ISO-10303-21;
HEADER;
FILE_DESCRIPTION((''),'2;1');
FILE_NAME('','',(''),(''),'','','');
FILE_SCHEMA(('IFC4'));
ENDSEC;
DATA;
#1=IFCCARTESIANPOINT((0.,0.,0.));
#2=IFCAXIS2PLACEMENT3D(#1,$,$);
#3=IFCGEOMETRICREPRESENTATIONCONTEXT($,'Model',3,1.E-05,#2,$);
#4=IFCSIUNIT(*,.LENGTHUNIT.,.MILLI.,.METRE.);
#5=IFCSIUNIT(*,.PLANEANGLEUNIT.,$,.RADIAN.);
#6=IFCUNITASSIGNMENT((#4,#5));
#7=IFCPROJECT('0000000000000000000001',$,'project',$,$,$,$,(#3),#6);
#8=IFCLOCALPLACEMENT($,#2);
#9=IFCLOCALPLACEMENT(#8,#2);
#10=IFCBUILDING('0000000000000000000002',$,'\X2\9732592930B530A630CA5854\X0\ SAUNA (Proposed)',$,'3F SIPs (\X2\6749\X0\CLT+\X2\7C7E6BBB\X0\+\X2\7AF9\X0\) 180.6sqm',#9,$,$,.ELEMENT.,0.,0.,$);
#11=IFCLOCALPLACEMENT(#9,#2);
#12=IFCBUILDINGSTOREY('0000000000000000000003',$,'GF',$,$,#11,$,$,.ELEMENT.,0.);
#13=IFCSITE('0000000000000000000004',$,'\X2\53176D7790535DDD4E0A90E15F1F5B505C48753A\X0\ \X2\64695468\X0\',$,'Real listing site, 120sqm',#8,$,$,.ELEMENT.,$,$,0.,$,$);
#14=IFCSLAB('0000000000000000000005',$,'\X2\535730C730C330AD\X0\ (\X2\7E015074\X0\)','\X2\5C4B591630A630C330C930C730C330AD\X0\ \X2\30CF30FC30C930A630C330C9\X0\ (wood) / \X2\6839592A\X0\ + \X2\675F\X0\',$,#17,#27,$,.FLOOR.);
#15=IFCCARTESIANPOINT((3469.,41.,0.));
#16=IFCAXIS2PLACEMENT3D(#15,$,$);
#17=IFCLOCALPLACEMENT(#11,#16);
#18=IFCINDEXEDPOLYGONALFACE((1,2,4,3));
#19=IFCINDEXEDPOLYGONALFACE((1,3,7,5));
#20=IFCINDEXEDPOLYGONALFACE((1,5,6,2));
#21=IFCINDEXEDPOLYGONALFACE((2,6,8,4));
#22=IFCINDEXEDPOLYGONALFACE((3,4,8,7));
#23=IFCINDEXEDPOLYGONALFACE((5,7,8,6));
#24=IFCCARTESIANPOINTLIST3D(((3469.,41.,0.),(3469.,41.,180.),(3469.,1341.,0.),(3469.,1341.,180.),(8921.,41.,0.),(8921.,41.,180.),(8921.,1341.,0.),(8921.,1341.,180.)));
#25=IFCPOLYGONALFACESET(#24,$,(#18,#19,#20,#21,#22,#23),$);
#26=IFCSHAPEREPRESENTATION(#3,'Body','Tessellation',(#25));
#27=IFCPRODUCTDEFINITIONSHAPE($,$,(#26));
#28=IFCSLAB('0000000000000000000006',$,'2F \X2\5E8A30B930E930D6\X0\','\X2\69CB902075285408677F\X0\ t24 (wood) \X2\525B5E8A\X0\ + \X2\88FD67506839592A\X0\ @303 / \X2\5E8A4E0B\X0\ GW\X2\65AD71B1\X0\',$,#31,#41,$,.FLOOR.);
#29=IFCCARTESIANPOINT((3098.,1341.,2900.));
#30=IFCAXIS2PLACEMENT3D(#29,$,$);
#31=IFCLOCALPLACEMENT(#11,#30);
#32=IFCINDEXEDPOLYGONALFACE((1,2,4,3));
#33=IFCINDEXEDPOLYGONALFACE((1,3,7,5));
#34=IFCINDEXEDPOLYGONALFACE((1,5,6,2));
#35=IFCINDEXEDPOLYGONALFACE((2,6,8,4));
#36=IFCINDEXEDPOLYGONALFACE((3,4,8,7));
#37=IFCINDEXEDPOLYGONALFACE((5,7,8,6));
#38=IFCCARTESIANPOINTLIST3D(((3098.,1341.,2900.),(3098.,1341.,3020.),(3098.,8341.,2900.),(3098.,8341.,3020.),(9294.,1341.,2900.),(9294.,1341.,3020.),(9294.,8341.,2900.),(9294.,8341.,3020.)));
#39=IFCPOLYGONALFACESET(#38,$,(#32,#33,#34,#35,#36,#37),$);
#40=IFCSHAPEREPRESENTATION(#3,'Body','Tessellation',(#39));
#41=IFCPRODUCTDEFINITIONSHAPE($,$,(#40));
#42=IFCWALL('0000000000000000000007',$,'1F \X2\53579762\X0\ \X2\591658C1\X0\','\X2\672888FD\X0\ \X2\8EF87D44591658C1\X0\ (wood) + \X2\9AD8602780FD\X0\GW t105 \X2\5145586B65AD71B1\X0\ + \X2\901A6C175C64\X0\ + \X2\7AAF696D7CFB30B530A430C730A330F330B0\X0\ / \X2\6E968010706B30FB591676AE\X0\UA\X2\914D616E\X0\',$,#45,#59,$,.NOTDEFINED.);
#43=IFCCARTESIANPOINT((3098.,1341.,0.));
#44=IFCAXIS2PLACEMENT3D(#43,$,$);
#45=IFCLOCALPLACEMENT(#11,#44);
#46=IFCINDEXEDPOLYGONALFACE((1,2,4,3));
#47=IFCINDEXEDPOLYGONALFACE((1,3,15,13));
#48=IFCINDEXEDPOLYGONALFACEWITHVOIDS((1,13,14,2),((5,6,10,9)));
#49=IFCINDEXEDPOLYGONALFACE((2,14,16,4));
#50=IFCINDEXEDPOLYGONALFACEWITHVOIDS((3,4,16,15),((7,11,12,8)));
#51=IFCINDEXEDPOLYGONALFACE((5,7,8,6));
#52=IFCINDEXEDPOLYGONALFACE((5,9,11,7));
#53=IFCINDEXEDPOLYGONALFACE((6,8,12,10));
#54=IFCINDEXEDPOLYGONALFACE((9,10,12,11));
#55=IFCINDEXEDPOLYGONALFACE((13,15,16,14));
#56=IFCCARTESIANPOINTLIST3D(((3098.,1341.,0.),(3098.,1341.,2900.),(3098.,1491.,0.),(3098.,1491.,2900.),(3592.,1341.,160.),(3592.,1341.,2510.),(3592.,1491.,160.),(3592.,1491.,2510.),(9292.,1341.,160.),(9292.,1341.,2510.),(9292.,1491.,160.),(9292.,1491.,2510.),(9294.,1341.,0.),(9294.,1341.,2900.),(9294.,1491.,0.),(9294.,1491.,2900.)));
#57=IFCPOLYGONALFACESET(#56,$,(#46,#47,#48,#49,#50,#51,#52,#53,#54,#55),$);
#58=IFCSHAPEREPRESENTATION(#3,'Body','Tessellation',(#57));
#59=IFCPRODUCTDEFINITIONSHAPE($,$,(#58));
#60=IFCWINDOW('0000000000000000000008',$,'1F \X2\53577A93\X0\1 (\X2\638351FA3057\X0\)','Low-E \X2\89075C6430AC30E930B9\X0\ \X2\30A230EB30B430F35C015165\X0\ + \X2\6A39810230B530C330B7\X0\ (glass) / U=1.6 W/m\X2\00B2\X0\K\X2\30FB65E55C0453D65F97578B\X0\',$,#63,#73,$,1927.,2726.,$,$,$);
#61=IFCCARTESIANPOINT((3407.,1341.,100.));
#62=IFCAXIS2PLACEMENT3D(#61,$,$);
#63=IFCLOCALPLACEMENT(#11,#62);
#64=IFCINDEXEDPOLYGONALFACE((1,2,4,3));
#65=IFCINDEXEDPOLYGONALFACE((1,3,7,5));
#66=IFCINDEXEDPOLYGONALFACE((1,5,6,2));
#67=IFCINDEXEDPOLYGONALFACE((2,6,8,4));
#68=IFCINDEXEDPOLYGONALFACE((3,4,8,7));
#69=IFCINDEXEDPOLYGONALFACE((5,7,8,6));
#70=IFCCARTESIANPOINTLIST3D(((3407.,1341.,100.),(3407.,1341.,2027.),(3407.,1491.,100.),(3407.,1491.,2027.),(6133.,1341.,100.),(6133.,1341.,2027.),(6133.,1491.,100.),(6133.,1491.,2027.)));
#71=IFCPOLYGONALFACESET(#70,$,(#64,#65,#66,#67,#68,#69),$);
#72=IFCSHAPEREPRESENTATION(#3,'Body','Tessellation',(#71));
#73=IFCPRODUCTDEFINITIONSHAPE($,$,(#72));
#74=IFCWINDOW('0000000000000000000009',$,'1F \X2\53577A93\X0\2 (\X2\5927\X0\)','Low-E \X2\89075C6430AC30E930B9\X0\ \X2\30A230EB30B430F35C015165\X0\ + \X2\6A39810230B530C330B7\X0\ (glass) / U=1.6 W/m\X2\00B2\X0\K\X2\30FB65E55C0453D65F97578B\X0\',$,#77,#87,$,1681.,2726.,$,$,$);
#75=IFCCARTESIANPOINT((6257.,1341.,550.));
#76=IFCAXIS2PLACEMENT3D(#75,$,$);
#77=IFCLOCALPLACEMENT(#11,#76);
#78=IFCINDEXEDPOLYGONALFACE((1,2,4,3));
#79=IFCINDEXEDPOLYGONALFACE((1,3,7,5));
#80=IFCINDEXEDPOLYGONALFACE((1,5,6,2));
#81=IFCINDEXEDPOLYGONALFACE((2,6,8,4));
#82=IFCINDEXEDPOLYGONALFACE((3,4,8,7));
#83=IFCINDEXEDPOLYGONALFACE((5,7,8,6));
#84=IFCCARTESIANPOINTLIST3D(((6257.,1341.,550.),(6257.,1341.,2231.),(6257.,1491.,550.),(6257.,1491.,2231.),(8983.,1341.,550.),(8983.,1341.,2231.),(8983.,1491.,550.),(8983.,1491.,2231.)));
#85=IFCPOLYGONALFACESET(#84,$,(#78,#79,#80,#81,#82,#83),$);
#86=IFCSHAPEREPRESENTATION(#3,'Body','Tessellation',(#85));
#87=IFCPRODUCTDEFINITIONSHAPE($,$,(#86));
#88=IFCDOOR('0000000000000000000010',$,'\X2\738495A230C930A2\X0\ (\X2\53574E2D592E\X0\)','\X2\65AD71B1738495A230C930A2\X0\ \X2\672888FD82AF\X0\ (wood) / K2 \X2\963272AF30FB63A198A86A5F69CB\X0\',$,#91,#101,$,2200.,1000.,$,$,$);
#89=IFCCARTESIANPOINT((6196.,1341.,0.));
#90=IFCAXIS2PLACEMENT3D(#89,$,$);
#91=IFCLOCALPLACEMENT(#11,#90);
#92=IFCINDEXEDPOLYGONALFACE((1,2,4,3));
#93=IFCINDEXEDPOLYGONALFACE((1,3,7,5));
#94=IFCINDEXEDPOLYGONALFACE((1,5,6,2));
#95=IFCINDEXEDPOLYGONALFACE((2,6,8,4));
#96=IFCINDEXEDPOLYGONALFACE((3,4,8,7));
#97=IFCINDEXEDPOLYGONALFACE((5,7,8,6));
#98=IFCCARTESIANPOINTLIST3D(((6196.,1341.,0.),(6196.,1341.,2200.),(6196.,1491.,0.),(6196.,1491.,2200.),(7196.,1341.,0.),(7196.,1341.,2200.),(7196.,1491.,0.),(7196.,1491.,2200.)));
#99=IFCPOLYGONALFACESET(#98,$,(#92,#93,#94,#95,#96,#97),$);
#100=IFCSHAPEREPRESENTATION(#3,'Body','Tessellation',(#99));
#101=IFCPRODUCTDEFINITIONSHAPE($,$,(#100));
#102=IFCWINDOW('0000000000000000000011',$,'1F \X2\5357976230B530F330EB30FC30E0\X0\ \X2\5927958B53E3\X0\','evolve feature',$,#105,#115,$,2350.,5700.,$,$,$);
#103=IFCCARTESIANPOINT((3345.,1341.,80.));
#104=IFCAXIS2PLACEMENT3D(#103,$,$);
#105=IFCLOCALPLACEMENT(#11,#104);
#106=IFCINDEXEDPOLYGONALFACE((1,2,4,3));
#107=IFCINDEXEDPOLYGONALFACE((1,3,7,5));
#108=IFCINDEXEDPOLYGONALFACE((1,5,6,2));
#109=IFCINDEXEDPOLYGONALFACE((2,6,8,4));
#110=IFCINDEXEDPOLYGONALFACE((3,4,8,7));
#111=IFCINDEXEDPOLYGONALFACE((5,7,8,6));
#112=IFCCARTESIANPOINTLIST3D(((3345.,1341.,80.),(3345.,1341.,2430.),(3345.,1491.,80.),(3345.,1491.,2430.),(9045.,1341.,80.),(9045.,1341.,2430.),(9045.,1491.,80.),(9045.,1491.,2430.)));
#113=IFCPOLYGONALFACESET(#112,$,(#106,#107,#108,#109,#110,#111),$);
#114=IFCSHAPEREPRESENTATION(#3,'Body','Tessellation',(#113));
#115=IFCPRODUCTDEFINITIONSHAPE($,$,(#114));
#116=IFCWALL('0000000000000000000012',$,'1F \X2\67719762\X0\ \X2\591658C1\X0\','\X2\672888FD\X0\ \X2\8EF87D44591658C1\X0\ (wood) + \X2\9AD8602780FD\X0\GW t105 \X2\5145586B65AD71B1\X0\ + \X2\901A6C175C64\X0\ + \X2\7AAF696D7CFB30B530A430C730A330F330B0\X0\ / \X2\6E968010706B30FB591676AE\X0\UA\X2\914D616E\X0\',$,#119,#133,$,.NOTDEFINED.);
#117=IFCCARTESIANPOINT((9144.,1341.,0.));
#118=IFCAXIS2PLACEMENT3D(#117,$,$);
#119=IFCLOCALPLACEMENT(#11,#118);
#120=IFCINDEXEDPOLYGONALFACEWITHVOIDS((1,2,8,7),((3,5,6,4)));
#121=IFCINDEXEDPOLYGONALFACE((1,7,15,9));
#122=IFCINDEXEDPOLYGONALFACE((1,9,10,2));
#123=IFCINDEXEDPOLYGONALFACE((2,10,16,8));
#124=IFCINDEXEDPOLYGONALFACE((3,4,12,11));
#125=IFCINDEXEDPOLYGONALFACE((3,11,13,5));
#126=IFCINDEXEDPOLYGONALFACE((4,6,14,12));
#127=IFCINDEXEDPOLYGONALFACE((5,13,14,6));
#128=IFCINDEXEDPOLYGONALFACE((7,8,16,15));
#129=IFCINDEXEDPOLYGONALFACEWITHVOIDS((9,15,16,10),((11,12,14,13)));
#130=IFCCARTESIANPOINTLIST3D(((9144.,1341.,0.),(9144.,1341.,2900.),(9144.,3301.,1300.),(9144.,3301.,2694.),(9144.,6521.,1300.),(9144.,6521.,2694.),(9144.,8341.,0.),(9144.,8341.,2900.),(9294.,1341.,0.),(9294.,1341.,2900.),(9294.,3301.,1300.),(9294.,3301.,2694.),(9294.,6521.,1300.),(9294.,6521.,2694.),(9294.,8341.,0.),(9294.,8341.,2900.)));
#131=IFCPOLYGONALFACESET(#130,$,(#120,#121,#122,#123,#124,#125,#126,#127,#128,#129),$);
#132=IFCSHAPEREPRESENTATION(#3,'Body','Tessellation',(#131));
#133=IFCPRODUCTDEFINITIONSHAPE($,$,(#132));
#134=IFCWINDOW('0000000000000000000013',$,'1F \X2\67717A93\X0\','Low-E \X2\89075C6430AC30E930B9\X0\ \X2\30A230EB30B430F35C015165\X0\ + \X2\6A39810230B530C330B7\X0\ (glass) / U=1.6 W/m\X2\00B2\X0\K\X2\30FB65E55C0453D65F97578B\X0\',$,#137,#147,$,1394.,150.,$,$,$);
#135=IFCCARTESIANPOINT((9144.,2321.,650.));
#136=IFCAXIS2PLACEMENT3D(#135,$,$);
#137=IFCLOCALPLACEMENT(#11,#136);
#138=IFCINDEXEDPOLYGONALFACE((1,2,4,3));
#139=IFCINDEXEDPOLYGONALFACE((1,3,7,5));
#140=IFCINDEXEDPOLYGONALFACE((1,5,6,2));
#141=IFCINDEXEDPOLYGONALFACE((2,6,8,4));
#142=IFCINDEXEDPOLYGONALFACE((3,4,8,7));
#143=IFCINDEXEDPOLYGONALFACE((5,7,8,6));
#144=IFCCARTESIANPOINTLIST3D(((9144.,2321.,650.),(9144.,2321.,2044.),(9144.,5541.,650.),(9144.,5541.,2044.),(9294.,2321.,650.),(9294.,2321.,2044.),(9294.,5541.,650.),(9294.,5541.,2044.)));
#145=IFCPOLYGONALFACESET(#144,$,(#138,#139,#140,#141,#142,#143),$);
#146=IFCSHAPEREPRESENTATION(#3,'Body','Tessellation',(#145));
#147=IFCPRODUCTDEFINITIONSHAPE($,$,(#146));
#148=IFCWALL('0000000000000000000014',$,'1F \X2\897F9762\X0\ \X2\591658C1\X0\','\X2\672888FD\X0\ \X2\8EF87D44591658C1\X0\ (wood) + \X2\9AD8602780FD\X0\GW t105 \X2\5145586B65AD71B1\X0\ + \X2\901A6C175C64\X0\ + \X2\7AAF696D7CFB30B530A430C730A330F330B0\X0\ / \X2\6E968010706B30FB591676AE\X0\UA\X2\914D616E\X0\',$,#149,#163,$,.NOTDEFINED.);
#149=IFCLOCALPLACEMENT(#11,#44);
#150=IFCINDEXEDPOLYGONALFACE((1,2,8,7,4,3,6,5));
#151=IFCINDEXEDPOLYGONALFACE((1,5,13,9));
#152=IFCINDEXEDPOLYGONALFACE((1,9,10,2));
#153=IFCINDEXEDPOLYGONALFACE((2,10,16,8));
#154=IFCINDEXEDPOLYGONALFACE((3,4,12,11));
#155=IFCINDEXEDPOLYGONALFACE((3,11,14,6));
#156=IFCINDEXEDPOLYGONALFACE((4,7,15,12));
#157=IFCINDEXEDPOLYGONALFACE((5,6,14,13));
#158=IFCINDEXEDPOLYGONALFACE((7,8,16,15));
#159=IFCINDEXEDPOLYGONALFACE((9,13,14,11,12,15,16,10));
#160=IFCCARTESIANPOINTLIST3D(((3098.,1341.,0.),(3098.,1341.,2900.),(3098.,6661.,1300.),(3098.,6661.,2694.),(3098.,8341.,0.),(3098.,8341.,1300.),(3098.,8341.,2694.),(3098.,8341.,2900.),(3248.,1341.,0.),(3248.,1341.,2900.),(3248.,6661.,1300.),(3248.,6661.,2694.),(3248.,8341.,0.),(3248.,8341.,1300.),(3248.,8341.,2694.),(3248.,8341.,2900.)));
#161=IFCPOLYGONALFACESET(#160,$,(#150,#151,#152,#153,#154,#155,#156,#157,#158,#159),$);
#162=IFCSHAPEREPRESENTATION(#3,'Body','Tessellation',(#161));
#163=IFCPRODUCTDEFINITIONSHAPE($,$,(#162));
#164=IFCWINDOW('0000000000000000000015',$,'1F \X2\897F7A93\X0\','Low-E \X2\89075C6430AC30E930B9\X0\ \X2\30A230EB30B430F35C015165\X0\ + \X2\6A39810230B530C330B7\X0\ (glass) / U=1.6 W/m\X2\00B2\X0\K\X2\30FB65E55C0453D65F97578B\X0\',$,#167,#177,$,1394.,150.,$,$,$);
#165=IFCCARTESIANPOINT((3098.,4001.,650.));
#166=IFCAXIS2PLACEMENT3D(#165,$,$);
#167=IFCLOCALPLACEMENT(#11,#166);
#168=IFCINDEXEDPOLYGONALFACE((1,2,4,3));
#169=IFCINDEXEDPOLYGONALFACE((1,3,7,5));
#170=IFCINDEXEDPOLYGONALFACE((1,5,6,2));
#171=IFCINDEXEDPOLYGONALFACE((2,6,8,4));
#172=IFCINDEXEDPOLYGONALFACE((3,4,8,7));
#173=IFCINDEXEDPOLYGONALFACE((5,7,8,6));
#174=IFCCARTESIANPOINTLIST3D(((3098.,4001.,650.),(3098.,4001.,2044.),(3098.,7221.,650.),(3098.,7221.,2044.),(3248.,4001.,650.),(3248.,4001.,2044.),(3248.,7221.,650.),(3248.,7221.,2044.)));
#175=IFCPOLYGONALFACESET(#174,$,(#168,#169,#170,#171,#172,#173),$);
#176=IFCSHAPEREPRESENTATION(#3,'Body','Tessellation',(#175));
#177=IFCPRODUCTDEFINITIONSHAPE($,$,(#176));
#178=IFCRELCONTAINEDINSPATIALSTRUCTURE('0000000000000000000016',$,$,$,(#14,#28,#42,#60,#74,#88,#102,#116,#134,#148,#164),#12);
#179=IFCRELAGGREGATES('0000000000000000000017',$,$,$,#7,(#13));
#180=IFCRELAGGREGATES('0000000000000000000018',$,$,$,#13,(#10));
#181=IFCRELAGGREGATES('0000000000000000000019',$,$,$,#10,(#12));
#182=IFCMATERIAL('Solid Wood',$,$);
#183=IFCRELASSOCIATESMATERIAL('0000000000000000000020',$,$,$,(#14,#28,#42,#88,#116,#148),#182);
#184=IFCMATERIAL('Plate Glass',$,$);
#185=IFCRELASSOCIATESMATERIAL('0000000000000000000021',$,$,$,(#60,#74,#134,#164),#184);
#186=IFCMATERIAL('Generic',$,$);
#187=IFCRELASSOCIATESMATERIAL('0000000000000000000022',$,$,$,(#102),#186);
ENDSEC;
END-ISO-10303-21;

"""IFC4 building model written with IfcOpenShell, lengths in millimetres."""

from ifc_helpers import new_model, si_unit, frame, frame_2d, origin, place, context, project, spatial, rectangle, extrude, material, element, fill, save


model = new_model("IFC4")

# Units and contexts
model_context = context("Model", 3, precision=1e-05, world=origin())
ifc_project = project(units=[si_unit("LENGTHUNIT", "METRE", prefix="MILLI"), si_unit("PLANEANGLEUNIT", "RADIAN")], contexts=[model_context])

# Site, building, storey
site_placement = place(None, origin())
site = spatial("IfcSite", under=ifc_project, at=site_placement, Name="北海道川上郡弟子屈町 摩周", ObjectType="Real listing site, 120sqm", CompositionType="ELEMENT", RefElevation=0.0)
building_placement = place(site_placement, origin())
building = spatial("IfcBuilding", under=site, at=building_placement, Name="露天サウナ塔 SAUNA (Proposed)", ObjectType="3F SIPs (杉CLT+籾殻+竹) 180.6sqm", CompositionType="ELEMENT", ElevationOfRefHeight=0.0, ElevationOfTerrain=0.0)
storey_placement = place(building_placement, origin())
storey = spatial("IfcBuildingStorey", under=building, at=storey_placement, Name="GF", CompositionType="ELEMENT", Elevation=0.0)

# Slabs
ifc_material_1 = material(Name="Solid Wood")
slab_1_placement = place(storey_placement, frame((3469.0, 41.0, 0.0)))
element("IfcSlab", 1, at=slab_1_placement, inside=storey, material=ifc_material_1, Name="南デッキ (縁側)", Description="屋外ウッドデッキ ハードウッド (wood) / 根太 + 束", PredefinedType="FLOOR", context=model_context, shape_type="SweptSolid", body=[
    extrude(rectangle(XDim=5452.0, YDim=1300.0, at=frame_2d((2726.0, 650.0))), frame((3469.0, 41.0, 0.0)), (0.0, 0.0, 1.0), 180.0),
])
slab_2_placement = place(storey_placement, frame((3098.0, 1341.0, 2900.0)))
element("IfcSlab", 2, at=slab_2_placement, inside=storey, material=ifc_material_1, Name="2F 床スラブ", Description="構造用合板 t24 (wood) 剛床 + 製材根太 @303 / 床下 GW断熱", PredefinedType="FLOOR", context=model_context, shape_type="SweptSolid", body=[
    extrude(rectangle(XDim=6196.0, YDim=7000.0, at=frame_2d((3098.0, 3500.0))), frame((3098.0, 1341.0, 2900.0)), (0.0, 0.0, 1.0), 120.0),
])

# Wall, openings, windows, door
wall_1_placement = place(storey_placement, frame((3098.0, 1341.0, 0.0)))
wall_1 = element("IfcWall", 3, at=wall_1_placement, inside=storey, material=ifc_material_1, Name="1F 南面 外壁", Description="木製 軸組外壁 (wood) + 高性能GW t105 充填断熱 + 通気層 + 窯業系サイディング / 準耐火・外皮UA配慮", PredefinedType="NOTDEFINED", context=model_context, shape_type="SweptSolid", body=[
    extrude(rectangle(XDim=6196.0, YDim=150.0, at=frame_2d((3098.0, 75.0))), frame((3098.0, 1341.0, 0.0)), (0.0, 0.0, 1.0), 2900.0),
])
opening_1_placement = place(storey_placement, frame((3407.0, 1341.0, 100.0)))
opening_1 = element("IfcOpeningElement", 4, at=opening_1_placement, cuts=wall_1, PredefinedType="NOTDEFINED", context=model_context, shape_type="SweptSolid", body=[
    extrude(rectangle(XDim=2726.0, YDim=150.0, at=frame_2d((1363.0, 75.0))), frame((3407.0, 1341.0, 100.0)), (0.0, 0.0, 1.0), 1927.0),
])
opening_2_placement = place(storey_placement, frame((6257.0, 1341.0, 550.0)))
opening_2 = element("IfcOpeningElement", 5, at=opening_2_placement, cuts=wall_1, PredefinedType="NOTDEFINED", context=model_context, shape_type="SweptSolid", body=[
    extrude(rectangle(XDim=2726.0, YDim=150.0, at=frame_2d((1363.0, 75.0))), frame((6257.0, 1341.0, 550.0)), (0.0, 0.0, 1.0), 1681.0),
])
opening_3_placement = place(storey_placement, frame((6196.0, 1341.0, 0.0)))
opening_3 = element("IfcOpeningElement", 6, at=opening_3_placement, cuts=wall_1, PredefinedType="NOTDEFINED", context=model_context, shape_type="SweptSolid", body=[
    extrude(rectangle(XDim=1000.0, YDim=150.0, at=frame_2d((500.0, 75.0))), frame((6196.0, 1341.0, 0.0)), (0.0, 0.0, 1.0), 2200.0),
])
opening_4_placement = place(storey_placement, frame((3345.0, 1341.0, 80.0)))
opening_4 = element("IfcOpeningElement", 7, at=opening_4_placement, cuts=wall_1, PredefinedType="NOTDEFINED", context=model_context, shape_type="SweptSolid", body=[
    extrude(rectangle(XDim=5700.0, YDim=150.0, at=frame_2d((2850.0, 75.0))), frame((3345.0, 1341.0, 80.0)), (0.0, 0.0, 1.0), 2350.0),
])
ifc_material_2 = material(Name="Plate Glass")
window_1_placement = place(storey_placement, frame((3407.0, 1341.0, 100.0)))
window_1 = element("IfcWindow", 8, at=window_1_placement, inside=storey, material=ifc_material_2, Name="1F 南窓1 (掃出し)", Description="Low-E 複層ガラス アルゴン封入 + 樹脂サッシ (glass) / U=1.6 W/m²K・日射取得型", OverallHeight=1927.0, OverallWidth=2726.0, context=model_context, shape_type="SweptSolid", body=[
    extrude(rectangle(XDim=2726.0, YDim=150.0, at=frame_2d((1363.0, 75.0))), frame((3407.0, 1341.0, 100.0)), (0.0, 0.0, 1.0), 1927.0),
])
fill(opening_1, window_1)
window_2_placement = place(storey_placement, frame((6257.0, 1341.0, 550.0)))
window_2 = element("IfcWindow", 9, at=window_2_placement, inside=storey, material=ifc_material_2, Name="1F 南窓2 (大)", Description="Low-E 複層ガラス アルゴン封入 + 樹脂サッシ (glass) / U=1.6 W/m²K・日射取得型", OverallHeight=1681.0, OverallWidth=2726.0, context=model_context, shape_type="SweptSolid", body=[
    extrude(rectangle(XDim=2726.0, YDim=150.0, at=frame_2d((1363.0, 75.0))), frame((6257.0, 1341.0, 550.0)), (0.0, 0.0, 1.0), 1681.0),
])
fill(opening_2, window_2)
door_placement = place(storey_placement, frame((6196.0, 1341.0, 0.0)))
door = element("IfcDoor", 10, at=door_placement, inside=storey, material=ifc_material_1, Name="玄関ドア (南中央)", Description="断熱玄関ドア 木製芯 (wood) / K2 防犯・採風機構", OverallHeight=2200.0, OverallWidth=1000.0, context=model_context, shape_type="SweptSolid", body=[
    extrude(rectangle(XDim=1000.0, YDim=150.0, at=frame_2d((500.0, 75.0))), frame((6196.0, 1341.0, 0.0)), (0.0, 0.0, 1.0), 2200.0),
])
fill(opening_3, door)
ifc_material_3 = material(Name="Generic")
window_3_placement = place(storey_placement, frame((3345.0, 1341.0, 80.0)))
window_3 = element("IfcWindow", 11, at=window_3_placement, inside=storey, material=ifc_material_3, Name="1F 南面サンルーム 大開口", Description="evolve feature", OverallHeight=2350.0, OverallWidth=5700.0, context=model_context, shape_type="SweptSolid", body=[
    extrude(rectangle(XDim=5700.0, YDim=150.0, at=frame_2d((2850.0, 75.0))), frame((3345.0, 1341.0, 80.0)), (0.0, 0.0, 1.0), 2350.0),
])
fill(opening_4, window_3)

# Walls, openings, windows
wall_2_placement = place(storey_placement, frame((9144.0, 1341.0, 0.0)))
wall_2 = element("IfcWall", 12, at=wall_2_placement, inside=storey, material=ifc_material_1, Name="1F 東面 外壁", Description="木製 軸組外壁 (wood) + 高性能GW t105 充填断熱 + 通気層 + 窯業系サイディング / 準耐火・外皮UA配慮", PredefinedType="NOTDEFINED", context=model_context, shape_type="SweptSolid", body=[
    extrude(rectangle(XDim=150.0, YDim=7000.0, at=frame_2d((75.0, 3500.0))), frame((9144.0, 1341.0, 0.0)), (0.0, 0.0, 1.0), 2900.0),
])
opening_5_placement = place(storey_placement, frame((9144.0, 2321.0, 650.0)))
opening_5 = element("IfcOpeningElement", 13, at=opening_5_placement, cuts=wall_2, PredefinedType="NOTDEFINED", context=model_context, shape_type="SweptSolid", body=[
    extrude(rectangle(XDim=150.0, YDim=3220.0, at=frame_2d((75.0, 1610.0))), frame((9144.0, 2321.0, 650.0)), (0.0, 0.0, 1.0), 1394.0),
])
window_4_placement = place(storey_placement, frame((9144.0, 2321.0, 650.0)))
window_4 = element("IfcWindow", 14, at=window_4_placement, inside=storey, material=ifc_material_2, Name="1F 東窓", Description="Low-E 複層ガラス アルゴン封入 + 樹脂サッシ (glass) / U=1.6 W/m²K・日射取得型", OverallHeight=1394.0, OverallWidth=150.0, context=model_context, shape_type="SweptSolid", body=[
    extrude(rectangle(XDim=150.0, YDim=3220.0, at=frame_2d((75.0, 1610.0))), frame((9144.0, 2321.0, 650.0)), (0.0, 0.0, 1.0), 1394.0),
])
fill(opening_5, window_4)
wall_3_placement = place(storey_placement, frame((3098.0, 1341.0, 0.0)))
wall_3 = element("IfcWall", 15, at=wall_3_placement, inside=storey, material=ifc_material_1, Name="1F 西面 外壁", Description="木製 軸組外壁 (wood) + 高性能GW t105 充填断熱 + 通気層 + 窯業系サイディング / 準耐火・外皮UA配慮", PredefinedType="NOTDEFINED", context=model_context, shape_type="SweptSolid", body=[
    extrude(rectangle(XDim=150.0, YDim=7000.0, at=frame_2d((75.0, 3500.0))), frame((3098.0, 1341.0, 0.0)), (0.0, 0.0, 1.0), 2900.0),
])
opening_6_placement = place(storey_placement, frame((3098.0, 4001.0, 650.0)))
opening_6 = element("IfcOpeningElement", 16, at=opening_6_placement, cuts=wall_3, PredefinedType="NOTDEFINED", context=model_context, shape_type="SweptSolid", body=[
    extrude(rectangle(XDim=150.0, YDim=3220.0, at=frame_2d((75.0, 1610.0))), frame((3098.0, 4001.0, 650.0)), (0.0, 0.0, 1.0), 1394.0),
])
window_5_placement = place(storey_placement, frame((3098.0, 4001.0, 650.0)))
window_5 = element("IfcWindow", 17, at=window_5_placement, inside=storey, material=ifc_material_2, Name="1F 西窓", Description="Low-E 複層ガラス アルゴン封入 + 樹脂サッシ (glass) / U=1.6 W/m²K・日射取得型", OverallHeight=1394.0, OverallWidth=150.0, context=model_context, shape_type="SweptSolid", body=[
    extrude(rectangle(XDim=150.0, YDim=3220.0, at=frame_2d((75.0, 1610.0))), frame((3098.0, 4001.0, 650.0)), (0.0, 0.0, 1.0), 1394.0),
])
fill(opening_6, window_5)

save(model, "model.ifc")
